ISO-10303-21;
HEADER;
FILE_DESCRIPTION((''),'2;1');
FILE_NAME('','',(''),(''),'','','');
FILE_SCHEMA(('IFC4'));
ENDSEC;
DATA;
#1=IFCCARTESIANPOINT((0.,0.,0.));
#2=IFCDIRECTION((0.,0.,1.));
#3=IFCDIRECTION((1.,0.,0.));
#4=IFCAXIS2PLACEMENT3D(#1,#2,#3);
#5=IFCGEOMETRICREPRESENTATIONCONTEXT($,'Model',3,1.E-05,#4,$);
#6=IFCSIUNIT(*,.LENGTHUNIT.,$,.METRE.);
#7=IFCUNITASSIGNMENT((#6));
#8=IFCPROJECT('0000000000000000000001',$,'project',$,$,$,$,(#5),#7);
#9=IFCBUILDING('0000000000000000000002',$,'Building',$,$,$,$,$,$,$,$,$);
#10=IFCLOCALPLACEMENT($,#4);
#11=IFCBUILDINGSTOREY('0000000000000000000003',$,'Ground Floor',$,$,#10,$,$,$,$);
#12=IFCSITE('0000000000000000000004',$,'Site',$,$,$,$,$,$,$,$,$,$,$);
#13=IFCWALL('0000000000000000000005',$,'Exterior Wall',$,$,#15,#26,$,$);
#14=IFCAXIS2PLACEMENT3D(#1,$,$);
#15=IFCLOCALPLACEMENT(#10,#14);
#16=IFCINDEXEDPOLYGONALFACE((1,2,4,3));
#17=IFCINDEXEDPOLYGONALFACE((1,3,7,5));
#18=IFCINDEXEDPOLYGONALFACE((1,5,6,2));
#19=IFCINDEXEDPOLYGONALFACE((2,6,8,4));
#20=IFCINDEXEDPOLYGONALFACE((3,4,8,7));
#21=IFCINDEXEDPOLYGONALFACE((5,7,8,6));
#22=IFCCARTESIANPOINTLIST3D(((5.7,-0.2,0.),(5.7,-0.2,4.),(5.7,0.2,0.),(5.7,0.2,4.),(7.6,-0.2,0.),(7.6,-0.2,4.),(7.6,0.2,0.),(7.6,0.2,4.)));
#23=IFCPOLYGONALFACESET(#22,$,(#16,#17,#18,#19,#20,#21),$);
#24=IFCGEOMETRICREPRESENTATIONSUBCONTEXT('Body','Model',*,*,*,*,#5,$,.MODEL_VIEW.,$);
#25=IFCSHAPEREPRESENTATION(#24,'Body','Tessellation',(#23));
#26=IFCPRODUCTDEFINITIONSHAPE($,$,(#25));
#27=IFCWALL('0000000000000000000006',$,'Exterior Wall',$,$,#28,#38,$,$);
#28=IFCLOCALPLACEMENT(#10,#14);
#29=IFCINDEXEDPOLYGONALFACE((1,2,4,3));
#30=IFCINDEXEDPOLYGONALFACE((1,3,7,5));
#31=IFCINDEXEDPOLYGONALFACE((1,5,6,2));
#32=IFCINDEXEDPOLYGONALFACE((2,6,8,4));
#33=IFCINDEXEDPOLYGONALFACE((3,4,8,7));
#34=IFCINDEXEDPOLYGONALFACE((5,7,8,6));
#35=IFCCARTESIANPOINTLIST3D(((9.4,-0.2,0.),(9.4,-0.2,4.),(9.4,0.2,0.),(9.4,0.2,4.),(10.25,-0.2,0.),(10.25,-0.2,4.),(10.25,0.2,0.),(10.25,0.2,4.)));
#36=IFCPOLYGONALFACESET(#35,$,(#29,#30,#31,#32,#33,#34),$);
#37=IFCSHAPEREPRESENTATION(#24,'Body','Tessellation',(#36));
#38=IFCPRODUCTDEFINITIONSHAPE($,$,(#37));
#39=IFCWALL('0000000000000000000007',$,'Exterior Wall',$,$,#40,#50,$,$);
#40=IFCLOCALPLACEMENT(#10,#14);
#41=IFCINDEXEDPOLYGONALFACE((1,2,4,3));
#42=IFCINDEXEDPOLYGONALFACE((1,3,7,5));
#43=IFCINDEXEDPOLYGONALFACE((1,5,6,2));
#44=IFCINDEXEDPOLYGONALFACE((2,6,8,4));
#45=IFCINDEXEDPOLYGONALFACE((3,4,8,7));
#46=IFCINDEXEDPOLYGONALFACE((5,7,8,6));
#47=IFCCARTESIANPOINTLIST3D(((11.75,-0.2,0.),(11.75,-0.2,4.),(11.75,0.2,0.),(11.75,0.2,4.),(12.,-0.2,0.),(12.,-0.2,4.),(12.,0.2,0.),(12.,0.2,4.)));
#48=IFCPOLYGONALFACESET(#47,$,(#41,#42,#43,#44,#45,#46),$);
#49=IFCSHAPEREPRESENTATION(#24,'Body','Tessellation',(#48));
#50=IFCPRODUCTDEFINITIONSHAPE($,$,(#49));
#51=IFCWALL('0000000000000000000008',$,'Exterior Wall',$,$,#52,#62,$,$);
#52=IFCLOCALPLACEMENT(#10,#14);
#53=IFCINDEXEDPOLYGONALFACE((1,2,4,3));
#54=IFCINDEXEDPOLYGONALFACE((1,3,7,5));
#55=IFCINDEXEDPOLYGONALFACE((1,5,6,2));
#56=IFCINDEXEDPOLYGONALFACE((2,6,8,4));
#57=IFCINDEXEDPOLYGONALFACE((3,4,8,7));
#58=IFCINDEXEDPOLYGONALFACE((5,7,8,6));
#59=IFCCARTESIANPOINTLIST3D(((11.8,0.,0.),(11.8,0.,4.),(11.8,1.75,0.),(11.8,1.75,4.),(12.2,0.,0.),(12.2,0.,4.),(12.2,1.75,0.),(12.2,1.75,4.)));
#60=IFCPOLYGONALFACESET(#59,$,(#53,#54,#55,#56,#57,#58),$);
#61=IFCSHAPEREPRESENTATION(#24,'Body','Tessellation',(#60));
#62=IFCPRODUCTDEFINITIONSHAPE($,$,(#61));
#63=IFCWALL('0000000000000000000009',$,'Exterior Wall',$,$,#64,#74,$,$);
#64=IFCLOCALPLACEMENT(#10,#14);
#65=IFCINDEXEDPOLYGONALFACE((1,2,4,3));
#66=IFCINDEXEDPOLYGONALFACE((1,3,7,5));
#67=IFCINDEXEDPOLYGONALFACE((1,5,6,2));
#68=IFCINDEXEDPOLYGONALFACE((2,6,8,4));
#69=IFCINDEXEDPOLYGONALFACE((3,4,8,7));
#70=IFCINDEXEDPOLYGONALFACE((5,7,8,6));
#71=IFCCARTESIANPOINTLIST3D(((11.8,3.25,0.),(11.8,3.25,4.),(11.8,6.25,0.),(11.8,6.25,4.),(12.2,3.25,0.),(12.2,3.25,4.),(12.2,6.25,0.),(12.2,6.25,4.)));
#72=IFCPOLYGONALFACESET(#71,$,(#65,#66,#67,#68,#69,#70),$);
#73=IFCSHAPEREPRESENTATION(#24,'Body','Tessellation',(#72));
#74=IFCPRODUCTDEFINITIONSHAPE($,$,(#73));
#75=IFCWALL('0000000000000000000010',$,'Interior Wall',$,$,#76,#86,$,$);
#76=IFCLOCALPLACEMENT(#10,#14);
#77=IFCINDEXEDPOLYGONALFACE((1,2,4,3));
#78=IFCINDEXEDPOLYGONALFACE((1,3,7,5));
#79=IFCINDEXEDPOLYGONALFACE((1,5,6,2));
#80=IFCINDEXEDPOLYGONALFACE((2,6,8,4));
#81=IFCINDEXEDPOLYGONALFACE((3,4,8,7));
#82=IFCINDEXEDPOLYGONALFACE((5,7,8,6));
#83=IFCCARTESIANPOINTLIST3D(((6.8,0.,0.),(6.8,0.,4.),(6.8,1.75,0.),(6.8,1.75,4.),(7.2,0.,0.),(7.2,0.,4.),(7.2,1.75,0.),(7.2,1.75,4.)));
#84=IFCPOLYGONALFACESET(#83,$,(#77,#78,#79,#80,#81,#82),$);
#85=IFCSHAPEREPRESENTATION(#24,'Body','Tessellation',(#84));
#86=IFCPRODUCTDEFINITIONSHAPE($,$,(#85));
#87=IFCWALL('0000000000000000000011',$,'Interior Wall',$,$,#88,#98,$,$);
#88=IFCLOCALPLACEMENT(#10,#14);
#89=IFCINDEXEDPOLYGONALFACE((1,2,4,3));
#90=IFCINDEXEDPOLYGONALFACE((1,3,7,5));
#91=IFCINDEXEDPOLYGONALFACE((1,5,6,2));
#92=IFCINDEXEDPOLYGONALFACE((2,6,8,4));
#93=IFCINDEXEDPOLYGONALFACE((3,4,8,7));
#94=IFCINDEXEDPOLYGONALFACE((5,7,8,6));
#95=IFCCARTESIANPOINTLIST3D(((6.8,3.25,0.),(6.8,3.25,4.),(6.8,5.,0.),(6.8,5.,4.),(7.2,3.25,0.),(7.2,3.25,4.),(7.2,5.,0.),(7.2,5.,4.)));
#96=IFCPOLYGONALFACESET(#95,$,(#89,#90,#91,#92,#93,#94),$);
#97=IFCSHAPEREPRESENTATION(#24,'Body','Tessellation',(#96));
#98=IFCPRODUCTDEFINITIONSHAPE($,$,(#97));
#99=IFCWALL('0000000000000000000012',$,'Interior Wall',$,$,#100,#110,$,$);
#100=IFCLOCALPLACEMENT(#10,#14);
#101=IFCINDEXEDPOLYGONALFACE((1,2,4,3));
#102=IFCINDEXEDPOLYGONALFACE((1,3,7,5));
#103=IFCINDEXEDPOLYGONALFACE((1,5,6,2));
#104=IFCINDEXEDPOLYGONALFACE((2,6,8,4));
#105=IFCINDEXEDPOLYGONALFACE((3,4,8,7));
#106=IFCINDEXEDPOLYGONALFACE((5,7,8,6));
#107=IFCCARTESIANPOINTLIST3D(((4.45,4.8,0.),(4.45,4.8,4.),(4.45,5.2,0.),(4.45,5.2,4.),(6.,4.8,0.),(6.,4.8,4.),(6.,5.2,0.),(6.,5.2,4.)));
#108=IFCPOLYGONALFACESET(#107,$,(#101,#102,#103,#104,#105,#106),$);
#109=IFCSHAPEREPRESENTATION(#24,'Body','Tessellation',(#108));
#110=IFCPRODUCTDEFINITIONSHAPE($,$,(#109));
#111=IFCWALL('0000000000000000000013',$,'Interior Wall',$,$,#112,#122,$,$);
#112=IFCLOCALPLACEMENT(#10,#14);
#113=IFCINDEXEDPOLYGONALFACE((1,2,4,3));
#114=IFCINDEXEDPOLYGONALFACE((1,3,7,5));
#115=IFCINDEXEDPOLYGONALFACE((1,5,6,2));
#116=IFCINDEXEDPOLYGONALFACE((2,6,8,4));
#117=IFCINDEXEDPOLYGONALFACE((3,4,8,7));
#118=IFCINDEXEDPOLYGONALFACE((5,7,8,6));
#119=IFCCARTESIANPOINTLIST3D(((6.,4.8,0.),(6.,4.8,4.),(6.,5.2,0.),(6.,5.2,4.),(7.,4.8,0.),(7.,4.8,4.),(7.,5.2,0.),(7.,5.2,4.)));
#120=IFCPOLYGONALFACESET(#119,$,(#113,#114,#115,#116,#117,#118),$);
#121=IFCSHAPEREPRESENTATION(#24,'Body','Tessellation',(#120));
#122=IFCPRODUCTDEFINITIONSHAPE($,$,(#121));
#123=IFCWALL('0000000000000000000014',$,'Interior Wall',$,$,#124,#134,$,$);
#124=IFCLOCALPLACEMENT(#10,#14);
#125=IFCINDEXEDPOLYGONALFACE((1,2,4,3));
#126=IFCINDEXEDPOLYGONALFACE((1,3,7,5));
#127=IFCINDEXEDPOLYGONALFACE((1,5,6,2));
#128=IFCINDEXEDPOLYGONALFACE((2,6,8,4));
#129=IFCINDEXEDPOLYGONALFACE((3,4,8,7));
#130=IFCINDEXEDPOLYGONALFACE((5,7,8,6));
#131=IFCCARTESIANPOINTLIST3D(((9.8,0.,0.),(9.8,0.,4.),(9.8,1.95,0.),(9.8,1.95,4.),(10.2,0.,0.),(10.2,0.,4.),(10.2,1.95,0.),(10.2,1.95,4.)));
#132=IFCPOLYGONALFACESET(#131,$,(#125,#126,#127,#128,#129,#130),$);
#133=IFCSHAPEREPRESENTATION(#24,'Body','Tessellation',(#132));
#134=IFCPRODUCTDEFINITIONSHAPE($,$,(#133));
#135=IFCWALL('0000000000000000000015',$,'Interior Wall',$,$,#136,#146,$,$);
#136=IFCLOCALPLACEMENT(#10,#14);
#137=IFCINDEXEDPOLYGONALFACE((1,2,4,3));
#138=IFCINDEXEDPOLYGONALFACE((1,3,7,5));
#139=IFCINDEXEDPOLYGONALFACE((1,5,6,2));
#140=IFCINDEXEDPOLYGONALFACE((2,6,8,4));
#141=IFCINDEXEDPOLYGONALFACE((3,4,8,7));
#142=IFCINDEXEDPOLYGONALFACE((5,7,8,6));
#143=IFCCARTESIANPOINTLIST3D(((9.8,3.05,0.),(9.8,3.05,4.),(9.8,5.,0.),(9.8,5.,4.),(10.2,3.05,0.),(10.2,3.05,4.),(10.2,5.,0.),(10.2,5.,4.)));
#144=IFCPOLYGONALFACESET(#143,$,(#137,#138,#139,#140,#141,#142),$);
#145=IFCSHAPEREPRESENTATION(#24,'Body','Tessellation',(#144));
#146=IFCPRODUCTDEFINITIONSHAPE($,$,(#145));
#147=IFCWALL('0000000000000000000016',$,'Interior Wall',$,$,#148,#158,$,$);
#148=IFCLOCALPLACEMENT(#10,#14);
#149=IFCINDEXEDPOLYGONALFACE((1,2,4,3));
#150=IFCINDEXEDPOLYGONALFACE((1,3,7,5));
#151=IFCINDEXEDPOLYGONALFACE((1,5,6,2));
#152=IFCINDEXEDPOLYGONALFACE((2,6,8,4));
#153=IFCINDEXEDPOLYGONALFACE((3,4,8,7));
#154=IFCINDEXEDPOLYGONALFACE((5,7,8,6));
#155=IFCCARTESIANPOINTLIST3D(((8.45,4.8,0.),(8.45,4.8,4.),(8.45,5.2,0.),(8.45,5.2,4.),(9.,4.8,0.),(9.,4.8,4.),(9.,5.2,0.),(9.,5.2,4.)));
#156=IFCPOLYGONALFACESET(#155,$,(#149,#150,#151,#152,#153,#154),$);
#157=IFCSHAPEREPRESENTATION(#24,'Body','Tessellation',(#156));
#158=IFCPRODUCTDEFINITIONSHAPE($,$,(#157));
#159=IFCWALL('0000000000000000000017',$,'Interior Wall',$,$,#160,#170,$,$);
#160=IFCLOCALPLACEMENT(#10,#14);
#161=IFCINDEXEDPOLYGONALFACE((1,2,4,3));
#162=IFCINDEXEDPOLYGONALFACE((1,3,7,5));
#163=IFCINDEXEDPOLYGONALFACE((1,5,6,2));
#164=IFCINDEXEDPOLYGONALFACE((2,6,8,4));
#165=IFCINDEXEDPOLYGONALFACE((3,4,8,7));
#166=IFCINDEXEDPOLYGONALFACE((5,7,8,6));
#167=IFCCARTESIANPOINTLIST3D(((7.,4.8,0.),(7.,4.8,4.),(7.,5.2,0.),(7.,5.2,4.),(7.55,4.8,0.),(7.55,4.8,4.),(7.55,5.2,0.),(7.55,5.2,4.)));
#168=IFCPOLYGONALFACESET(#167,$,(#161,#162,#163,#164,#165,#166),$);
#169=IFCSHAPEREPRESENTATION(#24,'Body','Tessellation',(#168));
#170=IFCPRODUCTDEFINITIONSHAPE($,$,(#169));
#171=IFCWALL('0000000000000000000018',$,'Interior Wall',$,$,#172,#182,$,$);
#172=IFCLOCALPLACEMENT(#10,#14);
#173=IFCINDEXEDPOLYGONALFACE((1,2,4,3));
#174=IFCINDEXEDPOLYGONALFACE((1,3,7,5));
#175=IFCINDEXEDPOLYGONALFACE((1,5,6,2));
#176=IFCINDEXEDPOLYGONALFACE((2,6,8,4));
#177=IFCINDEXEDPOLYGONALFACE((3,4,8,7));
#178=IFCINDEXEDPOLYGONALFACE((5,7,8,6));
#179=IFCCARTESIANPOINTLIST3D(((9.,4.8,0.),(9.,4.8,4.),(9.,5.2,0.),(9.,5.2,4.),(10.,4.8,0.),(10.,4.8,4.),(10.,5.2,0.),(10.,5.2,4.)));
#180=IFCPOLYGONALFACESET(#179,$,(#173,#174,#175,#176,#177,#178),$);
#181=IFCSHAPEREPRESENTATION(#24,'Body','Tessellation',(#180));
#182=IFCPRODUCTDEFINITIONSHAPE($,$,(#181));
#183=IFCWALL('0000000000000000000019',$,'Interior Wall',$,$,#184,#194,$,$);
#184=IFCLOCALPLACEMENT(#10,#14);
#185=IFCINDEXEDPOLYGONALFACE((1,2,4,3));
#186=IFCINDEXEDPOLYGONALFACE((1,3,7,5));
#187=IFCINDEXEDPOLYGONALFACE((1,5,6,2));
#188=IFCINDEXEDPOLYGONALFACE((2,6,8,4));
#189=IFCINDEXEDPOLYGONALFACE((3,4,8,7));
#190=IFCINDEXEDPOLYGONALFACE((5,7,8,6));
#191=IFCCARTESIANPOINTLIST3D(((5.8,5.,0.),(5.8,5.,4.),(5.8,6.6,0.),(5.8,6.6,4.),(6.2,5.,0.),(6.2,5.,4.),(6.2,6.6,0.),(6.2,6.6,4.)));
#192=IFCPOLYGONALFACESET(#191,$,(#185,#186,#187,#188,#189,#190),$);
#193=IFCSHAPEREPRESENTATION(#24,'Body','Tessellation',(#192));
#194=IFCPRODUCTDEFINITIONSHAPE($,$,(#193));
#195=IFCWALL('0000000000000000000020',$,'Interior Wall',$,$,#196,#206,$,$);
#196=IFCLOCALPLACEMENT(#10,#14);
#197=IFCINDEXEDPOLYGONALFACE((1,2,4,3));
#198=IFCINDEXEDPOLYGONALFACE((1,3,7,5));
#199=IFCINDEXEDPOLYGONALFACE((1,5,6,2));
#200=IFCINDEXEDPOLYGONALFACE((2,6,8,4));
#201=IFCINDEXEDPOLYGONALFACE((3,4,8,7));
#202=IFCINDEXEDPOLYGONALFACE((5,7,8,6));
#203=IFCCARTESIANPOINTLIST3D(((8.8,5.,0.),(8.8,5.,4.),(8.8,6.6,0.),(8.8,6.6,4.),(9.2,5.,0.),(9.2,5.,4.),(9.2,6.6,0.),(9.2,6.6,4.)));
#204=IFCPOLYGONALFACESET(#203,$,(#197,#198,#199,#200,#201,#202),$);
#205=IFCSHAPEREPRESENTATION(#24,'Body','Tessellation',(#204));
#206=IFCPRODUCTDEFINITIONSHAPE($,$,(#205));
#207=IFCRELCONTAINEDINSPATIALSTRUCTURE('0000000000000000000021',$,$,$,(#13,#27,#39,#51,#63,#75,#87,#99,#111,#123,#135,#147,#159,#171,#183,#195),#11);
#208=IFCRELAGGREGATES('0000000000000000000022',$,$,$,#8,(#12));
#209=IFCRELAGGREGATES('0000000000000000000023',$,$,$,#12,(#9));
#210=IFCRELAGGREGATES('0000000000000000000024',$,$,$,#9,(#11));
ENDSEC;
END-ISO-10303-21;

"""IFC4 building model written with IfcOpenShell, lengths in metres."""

from ifc_helpers import new_model, si_unit, frame, origin_with_axes, place, context, subcontext, project, spatial, indexed_curve, outline, extrude, element, save


model = new_model("IFC4")

# Units and contexts
model_context = context("Model", 3, precision=1e-05, world=origin_with_axes())
body_context = subcontext(model_context, "Body", "Model", "MODEL_VIEW")
ifc_project = project(units=[si_unit("LENGTHUNIT", "METRE")], contexts=[model_context])

# Site, building, storey
site = spatial("IfcSite", under=ifc_project, Name="Site")
building = spatial("IfcBuilding", under=site, Name="Building")
storey_placement = place(None, origin_with_axes())
storey = spatial("IfcBuildingStorey", under=building, at=storey_placement, Name="Ground Floor")

# Walls
wall_1_placement = place(storey_placement, frame((5.7, 0.0, 0.0), z_axis=(0.0, 0.0, 1.0), x_axis=(1.0, 0.0, 0.0)))
element("IfcWall", 1, at=wall_1_placement, inside=storey, Name="Exterior Wall", context=body_context, shape_type="SweptSolid", body=[
    extrude(outline(indexed_curve([(0.0, 0.0), (0.0, 0.4), (1.9, 0.4), (1.9, 0.0), (0.0, 0.0)], self_intersect=False)), frame((0.0, -0.2, 0.0), z_axis=(0.0, 0.0, 1.0), x_axis=(1.0, 0.0, 0.0)), (0.0, 0.0, 1.0), 4.0),
])
wall_2_placement = place(storey_placement, frame((9.4, 0.0, 0.0), z_axis=(0.0, 0.0, 1.0), x_axis=(1.0, 0.0, 0.0)))
element("IfcWall", 2, at=wall_2_placement, inside=storey, Name="Exterior Wall", context=body_context, shape_type="SweptSolid", body=[
    extrude(outline(indexed_curve([(0.0, 0.0), (0.0, 0.4), (0.85, 0.4), (0.85, 0.0), (0.0, 0.0)], self_intersect=False)), frame((0.0, -0.2, 0.0), z_axis=(0.0, 0.0, 1.0), x_axis=(1.0, 0.0, 0.0)), (0.0, 0.0, 1.0), 4.0),
])
wall_3_placement = place(storey_placement, frame((11.75, 0.0, 0.0), z_axis=(0.0, 0.0, 1.0), x_axis=(1.0, 0.0, 0.0)))
element("IfcWall", 3, at=wall_3_placement, inside=storey, Name="Exterior Wall", context=body_context, shape_type="SweptSolid", body=[
    extrude(outline(indexed_curve([(0.0, 0.0), (0.0, 0.4), (0.25, 0.4), (0.25, 0.0), (0.0, 0.0)], self_intersect=False)), frame((0.0, -0.2, 0.0), z_axis=(0.0, 0.0, 1.0), x_axis=(1.0, 0.0, 0.0)), (0.0, 0.0, 1.0), 4.0),
])
wall_4_placement = place(storey_placement, frame((12.0, 0.0, 0.0), z_axis=(0.0, 0.0, 1.0), x_axis=(0.0, 1.0, 0.0)))
element("IfcWall", 4, at=wall_4_placement, inside=storey, Name="Exterior Wall", context=body_context, shape_type="SweptSolid", body=[
    extrude(outline(indexed_curve([(0.0, 0.0), (0.0, 0.4), (1.75, 0.4), (1.75, 0.0), (0.0, 0.0)], self_intersect=False)), frame((0.0, -0.2, 0.0), z_axis=(0.0, 0.0, 1.0), x_axis=(1.0, 0.0, 0.0)), (0.0, 0.0, 1.0), 4.0),
])
wall_5_placement = place(storey_placement, frame((12.0, 3.25, 0.0), z_axis=(0.0, 0.0, 1.0), x_axis=(0.0, 1.0, 0.0)))
element("IfcWall", 5, at=wall_5_placement, inside=storey, Name="Exterior Wall", context=body_context, shape_type="SweptSolid", body=[
    extrude(outline(indexed_curve([(0.0, 0.0), (0.0, 0.4), (3.0, 0.4), (3.0, 0.0), (0.0, 0.0)], self_intersect=False)), frame((0.0, -0.2, 0.0), z_axis=(0.0, 0.0, 1.0), x_axis=(1.0, 0.0, 0.0)), (0.0, 0.0, 1.0), 4.0),
])
for number, where, z_axis, x_axis, name in (
    (6, (7.0, 0.0, 0.0), (0.0, 0.0, 1.0), (0.0, 1.0, 0.0), "Interior Wall"),
    (7, (7.0, 3.25, 0.0), (0.0, 0.0, 1.0), (0.0, 1.0, 0.0), "Interior Wall"),
):
    element("IfcWall", number, at=place(storey_placement, frame(where, z_axis=z_axis, x_axis=x_axis)), inside=storey, Name=name, context=body_context, shape_type="SweptSolid", body=[
        extrude(outline(indexed_curve([(0.0, 0.0), (0.0, 0.4), (1.75, 0.4), (1.75, 0.0), (0.0, 0.0)], self_intersect=False)), frame((0.0, -0.2, 0.0), z_axis=(0.0, 0.0, 1.0), x_axis=(1.0, 0.0, 0.0)), (0.0, 0.0, 1.0), 4.0),
    ])
wall_6_placement = place(storey_placement, frame((6.0, 5.0, 0.0), z_axis=(0.0, 0.0, 1.0), x_axis=(-1.0, 0.0, 0.0)))
element("IfcWall", 8, at=wall_6_placement, inside=storey, Name="Interior Wall", context=body_context, shape_type="SweptSolid", body=[
    extrude(outline(indexed_curve([(0.0, 0.0), (0.0, 0.4), (1.55, 0.4), (1.55, 0.0), (0.0, 0.0)], self_intersect=False)), frame((0.0, -0.2, 0.0), z_axis=(0.0, 0.0, 1.0), x_axis=(1.0, 0.0, 0.0)), (0.0, 0.0, 1.0), 4.0),
])
wall_7_placement = place(storey_placement, frame((7.0, 5.0, 0.0), z_axis=(0.0, 0.0, 1.0), x_axis=(-1.0, 0.0, 0.0)))
element("IfcWall", 9, at=wall_7_placement, inside=storey, Name="Interior Wall", context=body_context, shape_type="SweptSolid", body=[
    extrude(outline(indexed_curve([(0.0, 0.0), (0.0, 0.4), (1.0, 0.4), (1.0, 0.0), (0.0, 0.0)], self_intersect=False)), frame((0.0, -0.2, 0.0), z_axis=(0.0, 0.0, 1.0), x_axis=(1.0, 0.0, 0.0)), (0.0, 0.0, 1.0), 4.0),
])
wall_8_placement = place(storey_placement, frame((10.0, 0.0, 0.0), z_axis=(0.0, 0.0, 1.0), x_axis=(0.0, 1.0, 0.0)))
element("IfcWall", 10, at=wall_8_placement, inside=storey, Name="Interior Wall", context=body_context, shape_type="SweptSolid", body=[
    extrude(outline(indexed_curve([(0.0, 0.0), (0.0, 0.4), (1.95, 0.4), (1.95, 0.0), (0.0, 0.0)], self_intersect=False)), frame((0.0, -0.2, 0.0), z_axis=(0.0, 0.0, 1.0), x_axis=(1.0, 0.0, 0.0)), (0.0, 0.0, 1.0), 4.0),
])
wall_9_placement = place(storey_placement, frame((10.0, 3.05, 0.0), z_axis=(0.0, 0.0, 1.0), x_axis=(0.0, 1.0, 0.0)))
element("IfcWall", 11, at=wall_9_placement, inside=storey, Name="Interior Wall", context=body_context, shape_type="SweptSolid", body=[
    extrude(outline(indexed_curve([(0.0, 0.0), (0.0, 0.4), (1.95, 0.4), (1.95, 0.0), (0.0, 0.0)], self_intersect=False)), frame((0.0, -0.2, 0.0), z_axis=(0.0, 0.0, 1.0), x_axis=(1.0, 0.0, 0.0)), (0.0, 0.0, 1.0), 4.0),
])
wall_10_placement = place(storey_placement, frame((9.0, 5.0, 0.0), z_axis=(0.0, 0.0, 1.0), x_axis=(-1.0, 0.0, 0.0)))
element("IfcWall", 12, at=wall_10_placement, inside=storey, Name="Interior Wall", context=body_context, shape_type="SweptSolid", body=[
    extrude(outline(indexed_curve([(0.0, 0.0), (0.0, 0.4), (0.55, 0.4), (0.55, 0.0), (0.0, 0.0)], self_intersect=False)), frame((0.0, -0.2, 0.0), z_axis=(0.0, 0.0, 1.0), x_axis=(1.0, 0.0, 0.0)), (0.0, 0.0, 1.0), 4.0),
])
wall_11_placement = place(storey_placement, frame((7.55, 5.0, 0.0), z_axis=(0.0, 0.0, 1.0), x_axis=(-1.0, 0.0, 0.0)))
element("IfcWall", 13, at=wall_11_placement, inside=storey, Name="Interior Wall", context=body_context, shape_type="SweptSolid", body=[
    extrude(outline(indexed_curve([(0.0, 0.0), (0.0, 0.4), (0.55, 0.4), (0.55, 0.0), (0.0, 0.0)], self_intersect=False)), frame((0.0, -0.2, 0.0), z_axis=(0.0, 0.0, 1.0), x_axis=(1.0, 0.0, 0.0)), (0.0, 0.0, 1.0), 4.0),
])
wall_12_placement = place(storey_placement, frame((10.0, 5.0, 0.0), z_axis=(0.0, 0.0, 1.0), x_axis=(-1.0, 0.0, 0.0)))
element("IfcWall", 14, at=wall_12_placement, inside=storey, Name="Interior Wall", context=body_context, shape_type="SweptSolid", body=[
    extrude(outline(indexed_curve([(0.0, 0.0), (0.0, 0.4), (1.0, 0.4), (1.0, 0.0), (0.0, 0.0)], self_intersect=False)), frame((0.0, -0.2, 0.0), z_axis=(0.0, 0.0, 1.0), x_axis=(1.0, 0.0, 0.0)), (0.0, 0.0, 1.0), 4.0),
])
for number, where, z_axis, x_axis, name in (
    (15, (6.0, 5.0, 0.0), (0.0, 0.0, 1.0), (0.0, 1.0, 0.0), "Interior Wall"),
    (16, (9.0, 5.0, 0.0), (0.0, 0.0, 1.0), (0.0, 1.0, 0.0), "Interior Wall"),
):
    element("IfcWall", number, at=place(storey_placement, frame(where, z_axis=z_axis, x_axis=x_axis)), inside=storey, Name=name, context=body_context, shape_type="SweptSolid", body=[
        extrude(outline(indexed_curve([(0.0, 0.0), (0.0, 0.4), (1.6, 0.4), (1.6, 0.0), (0.0, 0.0)], self_intersect=False)), frame((0.0, -0.2, 0.0), z_axis=(0.0, 0.0, 1.0), x_axis=(1.0, 0.0, 0.0)), (0.0, 0.0, 1.0), 4.0),
    ])

save(model, "model.ifc")
